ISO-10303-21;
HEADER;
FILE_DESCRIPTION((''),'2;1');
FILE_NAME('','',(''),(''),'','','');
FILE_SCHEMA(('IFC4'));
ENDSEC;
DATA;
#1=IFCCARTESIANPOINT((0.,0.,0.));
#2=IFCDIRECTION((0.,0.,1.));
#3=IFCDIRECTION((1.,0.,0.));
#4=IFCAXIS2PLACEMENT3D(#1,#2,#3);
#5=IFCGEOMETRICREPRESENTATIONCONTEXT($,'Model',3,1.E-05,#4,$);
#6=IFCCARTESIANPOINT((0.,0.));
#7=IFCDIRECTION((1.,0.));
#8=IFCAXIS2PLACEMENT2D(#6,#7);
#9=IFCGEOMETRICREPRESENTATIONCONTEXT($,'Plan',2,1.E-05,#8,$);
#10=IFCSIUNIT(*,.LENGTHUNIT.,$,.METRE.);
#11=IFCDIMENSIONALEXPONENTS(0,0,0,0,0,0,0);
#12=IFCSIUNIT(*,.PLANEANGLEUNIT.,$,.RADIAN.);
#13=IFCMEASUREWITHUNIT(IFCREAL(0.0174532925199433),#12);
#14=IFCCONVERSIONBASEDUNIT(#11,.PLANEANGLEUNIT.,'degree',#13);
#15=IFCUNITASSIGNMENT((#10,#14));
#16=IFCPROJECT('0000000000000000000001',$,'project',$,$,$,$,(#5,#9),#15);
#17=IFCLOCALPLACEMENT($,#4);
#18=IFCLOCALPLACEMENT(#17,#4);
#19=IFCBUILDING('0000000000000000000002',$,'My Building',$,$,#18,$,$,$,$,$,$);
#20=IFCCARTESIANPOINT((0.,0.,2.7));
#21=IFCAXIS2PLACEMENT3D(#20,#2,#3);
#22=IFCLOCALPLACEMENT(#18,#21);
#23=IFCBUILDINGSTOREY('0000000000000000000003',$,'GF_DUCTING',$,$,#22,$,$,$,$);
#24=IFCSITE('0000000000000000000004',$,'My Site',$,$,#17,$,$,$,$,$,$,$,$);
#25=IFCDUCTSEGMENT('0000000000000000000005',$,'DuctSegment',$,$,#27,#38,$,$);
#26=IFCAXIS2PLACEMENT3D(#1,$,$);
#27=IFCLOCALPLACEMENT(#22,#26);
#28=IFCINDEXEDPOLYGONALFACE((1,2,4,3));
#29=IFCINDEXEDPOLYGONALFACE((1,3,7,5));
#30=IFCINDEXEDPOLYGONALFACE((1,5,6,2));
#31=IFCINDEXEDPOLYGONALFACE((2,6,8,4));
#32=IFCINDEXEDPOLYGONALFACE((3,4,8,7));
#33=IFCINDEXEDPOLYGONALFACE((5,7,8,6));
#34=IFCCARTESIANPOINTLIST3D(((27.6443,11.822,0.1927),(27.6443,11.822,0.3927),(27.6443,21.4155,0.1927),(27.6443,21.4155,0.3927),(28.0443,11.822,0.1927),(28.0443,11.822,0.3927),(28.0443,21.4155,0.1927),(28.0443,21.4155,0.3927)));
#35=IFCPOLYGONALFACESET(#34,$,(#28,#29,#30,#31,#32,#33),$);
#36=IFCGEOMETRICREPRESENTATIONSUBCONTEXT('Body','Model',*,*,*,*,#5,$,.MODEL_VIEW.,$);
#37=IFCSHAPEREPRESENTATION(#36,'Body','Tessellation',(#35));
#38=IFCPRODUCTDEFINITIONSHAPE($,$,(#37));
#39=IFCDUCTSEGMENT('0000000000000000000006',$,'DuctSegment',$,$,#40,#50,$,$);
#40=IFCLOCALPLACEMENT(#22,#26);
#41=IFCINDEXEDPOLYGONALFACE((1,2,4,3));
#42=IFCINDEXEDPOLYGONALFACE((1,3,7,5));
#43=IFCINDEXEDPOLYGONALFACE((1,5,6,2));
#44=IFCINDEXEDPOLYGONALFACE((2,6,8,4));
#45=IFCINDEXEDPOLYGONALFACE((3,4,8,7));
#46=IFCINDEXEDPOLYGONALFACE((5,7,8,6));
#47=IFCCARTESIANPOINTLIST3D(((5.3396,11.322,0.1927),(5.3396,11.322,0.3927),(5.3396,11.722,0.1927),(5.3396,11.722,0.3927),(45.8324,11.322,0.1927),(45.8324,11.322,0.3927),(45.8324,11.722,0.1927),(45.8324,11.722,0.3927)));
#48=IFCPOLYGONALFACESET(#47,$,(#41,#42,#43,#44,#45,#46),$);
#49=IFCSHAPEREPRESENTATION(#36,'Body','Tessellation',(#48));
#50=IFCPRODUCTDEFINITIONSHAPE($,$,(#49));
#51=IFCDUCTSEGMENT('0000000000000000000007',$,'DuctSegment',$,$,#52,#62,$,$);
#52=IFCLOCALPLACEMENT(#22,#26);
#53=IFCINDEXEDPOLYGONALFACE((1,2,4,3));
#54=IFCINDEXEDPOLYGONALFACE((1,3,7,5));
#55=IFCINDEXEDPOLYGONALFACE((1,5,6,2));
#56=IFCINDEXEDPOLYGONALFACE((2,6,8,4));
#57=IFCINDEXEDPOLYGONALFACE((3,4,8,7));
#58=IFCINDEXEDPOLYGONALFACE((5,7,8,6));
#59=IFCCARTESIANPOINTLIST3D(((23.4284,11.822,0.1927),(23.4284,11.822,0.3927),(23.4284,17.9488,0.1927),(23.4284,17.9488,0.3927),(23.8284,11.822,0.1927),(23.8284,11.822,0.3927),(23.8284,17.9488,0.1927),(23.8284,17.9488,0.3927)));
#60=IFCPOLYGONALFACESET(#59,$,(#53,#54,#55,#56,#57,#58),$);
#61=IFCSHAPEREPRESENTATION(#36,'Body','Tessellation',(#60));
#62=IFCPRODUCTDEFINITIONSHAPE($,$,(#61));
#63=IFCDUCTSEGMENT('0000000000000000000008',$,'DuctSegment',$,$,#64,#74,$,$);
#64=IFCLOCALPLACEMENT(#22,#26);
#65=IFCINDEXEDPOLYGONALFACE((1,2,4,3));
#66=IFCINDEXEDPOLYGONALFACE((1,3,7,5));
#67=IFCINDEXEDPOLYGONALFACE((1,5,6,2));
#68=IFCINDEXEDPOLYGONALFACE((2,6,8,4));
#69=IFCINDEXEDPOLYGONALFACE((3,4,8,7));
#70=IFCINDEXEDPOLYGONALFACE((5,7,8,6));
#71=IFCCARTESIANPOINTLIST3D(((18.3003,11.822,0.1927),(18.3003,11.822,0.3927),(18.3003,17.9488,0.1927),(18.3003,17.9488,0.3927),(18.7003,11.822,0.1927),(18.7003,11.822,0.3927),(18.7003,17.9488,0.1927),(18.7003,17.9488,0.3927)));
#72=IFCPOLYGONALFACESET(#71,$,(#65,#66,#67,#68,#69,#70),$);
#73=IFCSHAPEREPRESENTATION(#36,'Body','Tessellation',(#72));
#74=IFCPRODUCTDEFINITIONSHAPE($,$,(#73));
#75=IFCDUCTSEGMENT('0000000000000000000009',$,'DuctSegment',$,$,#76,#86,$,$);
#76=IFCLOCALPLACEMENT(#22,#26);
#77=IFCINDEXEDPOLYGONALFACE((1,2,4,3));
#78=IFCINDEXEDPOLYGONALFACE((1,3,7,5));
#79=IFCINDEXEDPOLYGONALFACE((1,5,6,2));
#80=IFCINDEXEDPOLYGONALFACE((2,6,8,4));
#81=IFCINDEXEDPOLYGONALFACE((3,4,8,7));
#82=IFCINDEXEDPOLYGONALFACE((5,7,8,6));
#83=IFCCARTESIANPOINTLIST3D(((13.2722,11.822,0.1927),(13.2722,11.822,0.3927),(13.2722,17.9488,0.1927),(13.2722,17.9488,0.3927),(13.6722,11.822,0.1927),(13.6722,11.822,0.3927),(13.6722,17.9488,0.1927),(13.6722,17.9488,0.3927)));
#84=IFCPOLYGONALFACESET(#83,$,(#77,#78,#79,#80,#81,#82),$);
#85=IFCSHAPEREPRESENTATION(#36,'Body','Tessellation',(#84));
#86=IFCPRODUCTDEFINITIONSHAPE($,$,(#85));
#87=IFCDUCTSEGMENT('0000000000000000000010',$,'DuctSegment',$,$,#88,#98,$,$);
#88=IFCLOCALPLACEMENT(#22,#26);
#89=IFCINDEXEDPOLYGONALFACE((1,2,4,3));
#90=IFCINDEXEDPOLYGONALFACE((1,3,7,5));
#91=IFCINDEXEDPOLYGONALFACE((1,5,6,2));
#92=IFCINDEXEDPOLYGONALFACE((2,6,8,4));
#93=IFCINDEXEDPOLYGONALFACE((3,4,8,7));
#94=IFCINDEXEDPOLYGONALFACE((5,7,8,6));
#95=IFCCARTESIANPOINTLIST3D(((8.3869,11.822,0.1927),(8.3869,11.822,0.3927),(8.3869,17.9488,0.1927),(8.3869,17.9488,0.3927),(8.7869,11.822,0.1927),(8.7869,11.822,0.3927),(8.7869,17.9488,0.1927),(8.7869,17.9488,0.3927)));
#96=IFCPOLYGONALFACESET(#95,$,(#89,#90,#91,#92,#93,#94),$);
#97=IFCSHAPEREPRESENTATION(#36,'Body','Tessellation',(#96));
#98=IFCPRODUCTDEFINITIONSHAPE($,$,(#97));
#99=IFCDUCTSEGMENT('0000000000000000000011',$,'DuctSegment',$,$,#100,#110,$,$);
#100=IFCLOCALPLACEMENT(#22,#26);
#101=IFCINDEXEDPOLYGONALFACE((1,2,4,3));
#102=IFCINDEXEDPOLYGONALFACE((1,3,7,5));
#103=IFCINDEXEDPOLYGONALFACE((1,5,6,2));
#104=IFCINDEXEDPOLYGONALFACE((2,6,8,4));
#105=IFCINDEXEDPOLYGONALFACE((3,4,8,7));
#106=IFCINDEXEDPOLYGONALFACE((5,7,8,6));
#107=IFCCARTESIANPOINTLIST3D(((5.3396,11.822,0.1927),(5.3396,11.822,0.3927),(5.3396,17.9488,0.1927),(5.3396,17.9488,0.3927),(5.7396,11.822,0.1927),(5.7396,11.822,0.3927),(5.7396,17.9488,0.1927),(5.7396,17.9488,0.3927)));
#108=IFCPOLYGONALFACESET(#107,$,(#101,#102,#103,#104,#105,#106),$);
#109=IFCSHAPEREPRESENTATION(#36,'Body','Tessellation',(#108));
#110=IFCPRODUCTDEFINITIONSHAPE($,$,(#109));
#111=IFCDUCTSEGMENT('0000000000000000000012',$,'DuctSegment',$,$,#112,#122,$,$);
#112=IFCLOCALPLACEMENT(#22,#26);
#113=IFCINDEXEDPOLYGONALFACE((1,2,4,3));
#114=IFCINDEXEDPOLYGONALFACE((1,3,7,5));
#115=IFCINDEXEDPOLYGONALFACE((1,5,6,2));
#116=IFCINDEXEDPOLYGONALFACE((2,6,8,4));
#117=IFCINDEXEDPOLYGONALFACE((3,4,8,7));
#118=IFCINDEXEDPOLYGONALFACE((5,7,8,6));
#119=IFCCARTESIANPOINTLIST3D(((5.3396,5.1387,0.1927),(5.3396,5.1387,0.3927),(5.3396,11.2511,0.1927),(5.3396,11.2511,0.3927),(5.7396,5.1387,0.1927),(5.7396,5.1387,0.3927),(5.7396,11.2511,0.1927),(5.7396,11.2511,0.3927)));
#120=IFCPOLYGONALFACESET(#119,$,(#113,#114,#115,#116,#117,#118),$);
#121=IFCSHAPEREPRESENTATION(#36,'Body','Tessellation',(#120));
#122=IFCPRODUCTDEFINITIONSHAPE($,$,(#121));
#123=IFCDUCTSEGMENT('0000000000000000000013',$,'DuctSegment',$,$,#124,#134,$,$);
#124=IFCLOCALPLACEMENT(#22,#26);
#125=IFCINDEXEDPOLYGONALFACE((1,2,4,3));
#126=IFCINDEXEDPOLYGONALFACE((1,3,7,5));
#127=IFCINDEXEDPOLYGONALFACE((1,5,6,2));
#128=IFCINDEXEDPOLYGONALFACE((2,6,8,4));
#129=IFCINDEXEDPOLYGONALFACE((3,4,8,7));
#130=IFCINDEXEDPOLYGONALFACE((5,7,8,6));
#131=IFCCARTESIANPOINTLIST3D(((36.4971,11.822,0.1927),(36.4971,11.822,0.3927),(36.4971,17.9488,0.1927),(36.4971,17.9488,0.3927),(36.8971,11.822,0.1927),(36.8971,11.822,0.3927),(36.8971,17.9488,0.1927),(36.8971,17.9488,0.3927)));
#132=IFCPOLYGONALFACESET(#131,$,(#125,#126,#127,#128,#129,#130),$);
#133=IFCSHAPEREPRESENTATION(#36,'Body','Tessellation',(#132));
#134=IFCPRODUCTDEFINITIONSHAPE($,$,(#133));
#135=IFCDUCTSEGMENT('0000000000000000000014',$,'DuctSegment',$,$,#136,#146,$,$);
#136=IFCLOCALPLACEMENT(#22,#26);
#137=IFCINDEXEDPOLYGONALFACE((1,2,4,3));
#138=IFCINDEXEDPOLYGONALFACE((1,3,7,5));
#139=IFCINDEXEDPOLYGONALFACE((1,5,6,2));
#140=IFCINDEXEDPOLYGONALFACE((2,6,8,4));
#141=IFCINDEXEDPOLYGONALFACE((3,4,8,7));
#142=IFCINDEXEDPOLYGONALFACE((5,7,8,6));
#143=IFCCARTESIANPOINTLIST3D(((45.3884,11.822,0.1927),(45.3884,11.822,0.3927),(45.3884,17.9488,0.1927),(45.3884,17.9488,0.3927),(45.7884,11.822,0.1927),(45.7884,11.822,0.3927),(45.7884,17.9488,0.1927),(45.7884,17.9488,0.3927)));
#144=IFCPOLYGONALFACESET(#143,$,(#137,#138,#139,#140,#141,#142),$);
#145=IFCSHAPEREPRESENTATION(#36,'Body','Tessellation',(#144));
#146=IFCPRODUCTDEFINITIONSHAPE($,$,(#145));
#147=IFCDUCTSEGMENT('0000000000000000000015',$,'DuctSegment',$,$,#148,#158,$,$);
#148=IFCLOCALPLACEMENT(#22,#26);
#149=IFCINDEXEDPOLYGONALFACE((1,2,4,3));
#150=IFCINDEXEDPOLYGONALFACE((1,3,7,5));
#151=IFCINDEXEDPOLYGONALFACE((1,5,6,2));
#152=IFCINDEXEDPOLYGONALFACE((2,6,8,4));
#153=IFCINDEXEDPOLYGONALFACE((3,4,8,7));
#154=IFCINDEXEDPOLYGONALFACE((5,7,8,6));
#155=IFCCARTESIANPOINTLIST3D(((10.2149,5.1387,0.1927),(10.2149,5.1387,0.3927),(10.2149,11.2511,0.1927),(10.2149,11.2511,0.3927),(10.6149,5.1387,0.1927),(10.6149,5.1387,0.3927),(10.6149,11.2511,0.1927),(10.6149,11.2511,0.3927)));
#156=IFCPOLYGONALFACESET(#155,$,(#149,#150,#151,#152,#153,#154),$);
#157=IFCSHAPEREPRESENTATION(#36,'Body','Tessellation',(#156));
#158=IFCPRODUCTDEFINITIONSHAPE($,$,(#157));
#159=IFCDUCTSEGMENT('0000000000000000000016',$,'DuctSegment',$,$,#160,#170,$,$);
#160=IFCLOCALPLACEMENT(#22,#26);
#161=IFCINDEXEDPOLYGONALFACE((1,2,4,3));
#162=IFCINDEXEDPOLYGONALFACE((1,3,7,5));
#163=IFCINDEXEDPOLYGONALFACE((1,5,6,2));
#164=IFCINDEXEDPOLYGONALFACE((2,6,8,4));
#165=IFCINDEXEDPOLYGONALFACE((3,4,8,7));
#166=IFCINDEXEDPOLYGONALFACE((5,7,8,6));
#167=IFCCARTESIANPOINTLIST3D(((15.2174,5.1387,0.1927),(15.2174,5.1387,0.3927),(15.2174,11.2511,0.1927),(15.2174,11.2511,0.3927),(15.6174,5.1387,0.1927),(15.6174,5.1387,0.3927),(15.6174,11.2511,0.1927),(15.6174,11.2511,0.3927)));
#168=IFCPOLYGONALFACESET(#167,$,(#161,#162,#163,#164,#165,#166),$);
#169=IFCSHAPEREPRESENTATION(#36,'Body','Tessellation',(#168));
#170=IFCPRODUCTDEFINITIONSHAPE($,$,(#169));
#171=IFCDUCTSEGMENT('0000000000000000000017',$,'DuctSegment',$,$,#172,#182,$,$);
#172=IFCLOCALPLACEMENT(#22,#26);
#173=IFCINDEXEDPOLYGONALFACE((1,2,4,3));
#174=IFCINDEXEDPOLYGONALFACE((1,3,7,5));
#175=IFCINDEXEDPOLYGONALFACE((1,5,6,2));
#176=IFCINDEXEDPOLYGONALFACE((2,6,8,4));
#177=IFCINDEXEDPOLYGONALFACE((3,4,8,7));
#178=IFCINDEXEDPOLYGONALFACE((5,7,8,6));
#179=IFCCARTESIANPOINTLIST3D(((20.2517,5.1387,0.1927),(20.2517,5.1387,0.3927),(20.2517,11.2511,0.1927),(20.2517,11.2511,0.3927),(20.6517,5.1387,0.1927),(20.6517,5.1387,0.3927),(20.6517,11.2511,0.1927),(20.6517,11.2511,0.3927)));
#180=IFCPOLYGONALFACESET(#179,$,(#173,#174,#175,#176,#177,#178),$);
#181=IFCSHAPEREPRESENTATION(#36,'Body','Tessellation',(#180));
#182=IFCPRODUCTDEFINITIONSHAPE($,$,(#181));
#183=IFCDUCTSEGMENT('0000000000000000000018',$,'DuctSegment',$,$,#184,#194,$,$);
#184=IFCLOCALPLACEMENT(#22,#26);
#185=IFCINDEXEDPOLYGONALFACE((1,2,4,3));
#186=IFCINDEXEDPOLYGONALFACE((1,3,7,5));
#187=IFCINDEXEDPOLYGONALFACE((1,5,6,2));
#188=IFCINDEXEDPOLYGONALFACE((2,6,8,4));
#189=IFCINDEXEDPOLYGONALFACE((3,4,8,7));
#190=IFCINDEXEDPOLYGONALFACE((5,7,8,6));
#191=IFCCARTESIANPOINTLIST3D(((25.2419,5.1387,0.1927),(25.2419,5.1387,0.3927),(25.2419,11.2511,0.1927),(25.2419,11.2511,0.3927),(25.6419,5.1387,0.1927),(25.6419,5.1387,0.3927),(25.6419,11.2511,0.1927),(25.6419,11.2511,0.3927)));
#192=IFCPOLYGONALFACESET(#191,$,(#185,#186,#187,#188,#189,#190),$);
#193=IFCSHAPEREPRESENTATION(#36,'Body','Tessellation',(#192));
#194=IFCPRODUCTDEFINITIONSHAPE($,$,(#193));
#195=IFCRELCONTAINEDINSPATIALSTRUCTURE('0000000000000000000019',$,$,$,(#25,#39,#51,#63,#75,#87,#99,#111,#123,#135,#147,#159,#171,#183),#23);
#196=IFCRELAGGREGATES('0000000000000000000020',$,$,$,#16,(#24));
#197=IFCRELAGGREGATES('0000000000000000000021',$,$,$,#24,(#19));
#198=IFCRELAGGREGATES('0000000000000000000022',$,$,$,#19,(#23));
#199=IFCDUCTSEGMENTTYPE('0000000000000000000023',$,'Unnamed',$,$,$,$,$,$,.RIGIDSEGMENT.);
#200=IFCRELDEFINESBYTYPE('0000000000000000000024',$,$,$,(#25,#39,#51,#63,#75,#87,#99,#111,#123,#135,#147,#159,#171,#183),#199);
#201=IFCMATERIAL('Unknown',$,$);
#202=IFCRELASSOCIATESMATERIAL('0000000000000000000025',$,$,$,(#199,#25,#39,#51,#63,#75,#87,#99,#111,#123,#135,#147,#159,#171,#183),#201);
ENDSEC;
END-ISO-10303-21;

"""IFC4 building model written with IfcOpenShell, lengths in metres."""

from ifc_helpers import new_model, entity, si_unit, converted_unit, frame, origin_with_axes, origin_2d_with_axis, place, context, subcontext, project, spatial, rectangle, extrude, material, material_profile, profile_set, profile_usage, type_object, element, save


model = new_model("IFC4")

# Units and contexts
model_context = context("Model", 3, precision=1e-05, world=origin_with_axes())
plan_context = context("Plan", 2, precision=1e-05, world=origin_2d_with_axis())
body_context = subcontext(model_context, "Body", "Model", "MODEL_VIEW")
ifc_project = project(units=[si_unit("LENGTHUNIT", "METRE"), converted_unit("PLANEANGLEUNIT", "degree", entity("IfcReal", 0.0174532925199433), si_unit("PLANEANGLEUNIT", "RADIAN"), dimensions=[0, 0, 0, 0, 0, 0, 0])], contexts=[model_context, plan_context])

# Site, building, storey
site_placement = place(None, origin_with_axes())
site = spatial("IfcSite", under=ifc_project, at=site_placement, Name="My Site")
building_placement = place(site_placement, origin_with_axes())
building = spatial("IfcBuilding", under=site, at=building_placement, Name="My Building")
storey_placement = place(building_placement, frame((0.0, 0.0, 2.7), z_axis=(0.0, 0.0, 1.0), x_axis=(1.0, 0.0, 0.0)))
storey = spatial("IfcBuildingStorey", under=building, at=storey_placement, Name="GF_DUCTING")

# Duct segments
ifc_material = material(Name="Unknown")
ifc_material_profile_1 = material_profile(ifc_material, rectangle(XDim=0.4, YDim=0.2))
ifc_profile_set_1 = profile_set([ifc_material_profile_1])
ifc_profile_usage_1 = profile_usage(ifc_profile_set_1, cardinal=5)
duct_segment_type = type_object("IfcDuctSegmentType", Name="Unnamed", PredefinedType="RIGIDSEGMENT", material=ifc_profile_set_1)
duct_segment_1_placement = place(storey_placement, frame((27.8443, 21.4155, 0.2927), z_axis=(0.0, -1.0, 0.0), x_axis=(1.0, 0.0, 0.0)))
element("IfcDuctSegment", 1, at=duct_segment_1_placement, inside=storey, type_object=duct_segment_type, material=ifc_profile_usage_1, Name="DuctSegment", context=body_context, shape_type="SweptSolid", body=[
    extrude(rectangle(XDim=0.4, YDim=0.2), origin_with_axes(), (0.0, 0.0, 1.0), 9.5935),
])
ifc_profile_usage_2 = profile_usage(ifc_profile_set_1, cardinal=5)
duct_segment_2_placement = place(storey_placement, frame((45.8324, 11.522, 0.2927), z_axis=(-1.0, 0.0, 0.0), x_axis=(0.0, -1.0, 0.0)))
element("IfcDuctSegment", 2, at=duct_segment_2_placement, inside=storey, type_object=duct_segment_type, material=ifc_profile_usage_2, Name="DuctSegment", context=body_context, shape_type="SweptSolid", body=[
    extrude(rectangle(XDim=0.4, YDim=0.2), origin_with_axes(), (0.0, 0.0, 1.0), 40.4928),
])
ifc_profile_usage_3 = profile_usage(ifc_profile_set_1, cardinal=5)
duct_segment_3_placement = place(storey_placement, frame((23.6284, 17.9488, 0.2927), z_axis=(0.0, -1.0, 0.0), x_axis=(1.0, 0.0, 0.0)))
element("IfcDuctSegment", 3, at=duct_segment_3_placement, inside=storey, type_object=duct_segment_type, material=ifc_profile_usage_3, Name="DuctSegment", context=body_context, shape_type="SweptSolid", body=[
    extrude(rectangle(XDim=0.4, YDim=0.2), origin_with_axes(), (0.0, 0.0, 1.0), 6.1268),
])
ifc_profile_usage_4 = profile_usage(ifc_profile_set_1, cardinal=5)
duct_segment_4_placement = place(storey_placement, frame((18.5003, 17.9488, 0.2927), z_axis=(0.0, -1.0, 0.0), x_axis=(1.0, 0.0, 0.0)))
element("IfcDuctSegment", 4, at=duct_segment_4_placement, inside=storey, type_object=duct_segment_type, material=ifc_profile_usage_4, Name="DuctSegment", context=body_context, shape_type="SweptSolid", body=[
    extrude(rectangle(XDim=0.4, YDim=0.2), origin_with_axes(), (0.0, 0.0, 1.0), 6.1268),
])
ifc_profile_usage_5 = profile_usage(ifc_profile_set_1, cardinal=5)
duct_segment_5_placement = place(storey_placement, frame((13.4722, 17.9488, 0.2927), z_axis=(0.0, -1.0, 0.0), x_axis=(1.0, 0.0, 0.0)))
element("IfcDuctSegment", 5, at=duct_segment_5_placement, inside=storey, type_object=duct_segment_type, material=ifc_profile_usage_5, Name="DuctSegment", context=body_context, shape_type="SweptSolid", body=[
    extrude(rectangle(XDim=0.4, YDim=0.2), origin_with_axes(), (0.0, 0.0, 1.0), 6.1268),
])
ifc_profile_usage_6 = profile_usage(ifc_profile_set_1, cardinal=5)
duct_segment_6_placement = place(storey_placement, frame((8.5869, 17.9488, 0.2927), z_axis=(0.0, -1.0, 0.0), x_axis=(1.0, 0.0, 0.0)))
element("IfcDuctSegment", 6, at=duct_segment_6_placement, inside=storey, type_object=duct_segment_type, material=ifc_profile_usage_6, Name="DuctSegment", context=body_context, shape_type="SweptSolid", body=[
    extrude(rectangle(XDim=0.4, YDim=0.2), origin_with_axes(), (0.0, 0.0, 1.0), 6.1268),
])
ifc_profile_usage_7 = profile_usage(ifc_profile_set_1, cardinal=5)
duct_segment_7_placement = place(storey_placement, frame((5.5396, 17.9488, 0.2927), z_axis=(0.0, -1.0, 0.0), x_axis=(1.0, 0.0, 0.0)))
element("IfcDuctSegment", 7, at=duct_segment_7_placement, inside=storey, type_object=duct_segment_type, material=ifc_profile_usage_7, Name="DuctSegment", context=body_context, shape_type="SweptSolid", body=[
    extrude(rectangle(XDim=0.4, YDim=0.2), origin_with_axes(), (0.0, 0.0, 1.0), 6.1268),
])
ifc_profile_usage_8 = profile_usage(ifc_profile_set_1, cardinal=5)
duct_segment_8_placement = place(storey_placement, frame((5.5396, 5.1387, 0.2927), z_axis=(0.0, 1.0, 0.0), x_axis=(-1.0, 0.0, 0.0)))
element("IfcDuctSegment", 8, at=duct_segment_8_placement, inside=storey, type_object=duct_segment_type, material=ifc_profile_usage_8, Name="DuctSegment", context=body_context, shape_type="SweptSolid", body=[
    extrude(rectangle(XDim=0.4, YDim=0.2), origin_with_axes(), (0.0, 0.0, 1.0), 6.1124),
])
ifc_profile_usage_9 = profile_usage(ifc_profile_set_1, cardinal=5)
duct_segment_9_placement = place(storey_placement, frame((36.6971, 17.9488, 0.2927), z_axis=(0.0, -1.0, 0.0), x_axis=(1.0, 0.0, 0.0)))
element("IfcDuctSegment", 9, at=duct_segment_9_placement, inside=storey, type_object=duct_segment_type, material=ifc_profile_usage_9, Name="DuctSegment", context=body_context, shape_type="SweptSolid", body=[
    extrude(rectangle(XDim=0.4, YDim=0.2), origin_with_axes(), (0.0, 0.0, 1.0), 6.1268),
])
ifc_profile_usage_10 = profile_usage(ifc_profile_set_1, cardinal=5)
duct_segment_10_placement = place(storey_placement, frame((45.5884, 17.9488, 0.2927), z_axis=(0.0, -1.0, 0.0), x_axis=(1.0, 0.0, 0.0)))
element("IfcDuctSegment", 10, at=duct_segment_10_placement, inside=storey, type_object=duct_segment_type, material=ifc_profile_usage_10, Name="DuctSegment", context=body_context, shape_type="SweptSolid", body=[
    extrude(rectangle(XDim=0.4, YDim=0.2), origin_with_axes(), (0.0, 0.0, 1.0), 6.1268),
])
ifc_profile_usage_11 = profile_usage(ifc_profile_set_1, cardinal=5)
duct_segment_11_placement = place(storey_placement, frame((10.4149, 5.1387, 0.2927), z_axis=(0.0, 1.0, 0.0), x_axis=(-1.0, 0.0, 0.0)))
element("IfcDuctSegment", 11, at=duct_segment_11_placement, inside=storey, type_object=duct_segment_type, material=ifc_profile_usage_11, Name="DuctSegment", context=body_context, shape_type="SweptSolid", body=[
    extrude(rectangle(XDim=0.4, YDim=0.2), origin_with_axes(), (0.0, 0.0, 1.0), 6.1124),
])
ifc_profile_usage_12 = profile_usage(ifc_profile_set_1, cardinal=5)
duct_segment_12_placement = place(storey_placement, frame((15.4174, 5.1387, 0.2927), z_axis=(0.0, 1.0, 0.0), x_axis=(-1.0, 0.0, 0.0)))
element("IfcDuctSegment", 12, at=duct_segment_12_placement, inside=storey, type_object=duct_segment_type, material=ifc_profile_usage_12, Name="DuctSegment", context=body_context, shape_type="SweptSolid", body=[
    extrude(rectangle(XDim=0.4, YDim=0.2), origin_with_axes(), (0.0, 0.0, 1.0), 6.1124),
])
ifc_profile_usage_13 = profile_usage(ifc_profile_set_1, cardinal=5)
duct_segment_13_placement = place(storey_placement, frame((20.4517, 5.1387, 0.2927), z_axis=(0.0, 1.0, 0.0), x_axis=(-1.0, 0.0, 0.0)))
element("IfcDuctSegment", 13, at=duct_segment_13_placement, inside=storey, type_object=duct_segment_type, material=ifc_profile_usage_13, Name="DuctSegment", context=body_context, shape_type="SweptSolid", body=[
    extrude(rectangle(XDim=0.4, YDim=0.2), origin_with_axes(), (0.0, 0.0, 1.0), 6.1124),
])
ifc_profile_usage_14 = profile_usage(ifc_profile_set_1, cardinal=5)
duct_segment_14_placement = place(storey_placement, frame((25.4419, 5.1387, 0.2927), z_axis=(0.0, 1.0, 0.0), x_axis=(-1.0, 0.0, 0.0)))
element("IfcDuctSegment", 14, at=duct_segment_14_placement, inside=storey, type_object=duct_segment_type, material=ifc_profile_usage_14, Name="DuctSegment", context=body_context, shape_type="SweptSolid", body=[
    extrude(rectangle(XDim=0.4, YDim=0.2), origin_with_axes(), (0.0, 0.0, 1.0), 6.1124),
])

save(model, "model.ifc")
